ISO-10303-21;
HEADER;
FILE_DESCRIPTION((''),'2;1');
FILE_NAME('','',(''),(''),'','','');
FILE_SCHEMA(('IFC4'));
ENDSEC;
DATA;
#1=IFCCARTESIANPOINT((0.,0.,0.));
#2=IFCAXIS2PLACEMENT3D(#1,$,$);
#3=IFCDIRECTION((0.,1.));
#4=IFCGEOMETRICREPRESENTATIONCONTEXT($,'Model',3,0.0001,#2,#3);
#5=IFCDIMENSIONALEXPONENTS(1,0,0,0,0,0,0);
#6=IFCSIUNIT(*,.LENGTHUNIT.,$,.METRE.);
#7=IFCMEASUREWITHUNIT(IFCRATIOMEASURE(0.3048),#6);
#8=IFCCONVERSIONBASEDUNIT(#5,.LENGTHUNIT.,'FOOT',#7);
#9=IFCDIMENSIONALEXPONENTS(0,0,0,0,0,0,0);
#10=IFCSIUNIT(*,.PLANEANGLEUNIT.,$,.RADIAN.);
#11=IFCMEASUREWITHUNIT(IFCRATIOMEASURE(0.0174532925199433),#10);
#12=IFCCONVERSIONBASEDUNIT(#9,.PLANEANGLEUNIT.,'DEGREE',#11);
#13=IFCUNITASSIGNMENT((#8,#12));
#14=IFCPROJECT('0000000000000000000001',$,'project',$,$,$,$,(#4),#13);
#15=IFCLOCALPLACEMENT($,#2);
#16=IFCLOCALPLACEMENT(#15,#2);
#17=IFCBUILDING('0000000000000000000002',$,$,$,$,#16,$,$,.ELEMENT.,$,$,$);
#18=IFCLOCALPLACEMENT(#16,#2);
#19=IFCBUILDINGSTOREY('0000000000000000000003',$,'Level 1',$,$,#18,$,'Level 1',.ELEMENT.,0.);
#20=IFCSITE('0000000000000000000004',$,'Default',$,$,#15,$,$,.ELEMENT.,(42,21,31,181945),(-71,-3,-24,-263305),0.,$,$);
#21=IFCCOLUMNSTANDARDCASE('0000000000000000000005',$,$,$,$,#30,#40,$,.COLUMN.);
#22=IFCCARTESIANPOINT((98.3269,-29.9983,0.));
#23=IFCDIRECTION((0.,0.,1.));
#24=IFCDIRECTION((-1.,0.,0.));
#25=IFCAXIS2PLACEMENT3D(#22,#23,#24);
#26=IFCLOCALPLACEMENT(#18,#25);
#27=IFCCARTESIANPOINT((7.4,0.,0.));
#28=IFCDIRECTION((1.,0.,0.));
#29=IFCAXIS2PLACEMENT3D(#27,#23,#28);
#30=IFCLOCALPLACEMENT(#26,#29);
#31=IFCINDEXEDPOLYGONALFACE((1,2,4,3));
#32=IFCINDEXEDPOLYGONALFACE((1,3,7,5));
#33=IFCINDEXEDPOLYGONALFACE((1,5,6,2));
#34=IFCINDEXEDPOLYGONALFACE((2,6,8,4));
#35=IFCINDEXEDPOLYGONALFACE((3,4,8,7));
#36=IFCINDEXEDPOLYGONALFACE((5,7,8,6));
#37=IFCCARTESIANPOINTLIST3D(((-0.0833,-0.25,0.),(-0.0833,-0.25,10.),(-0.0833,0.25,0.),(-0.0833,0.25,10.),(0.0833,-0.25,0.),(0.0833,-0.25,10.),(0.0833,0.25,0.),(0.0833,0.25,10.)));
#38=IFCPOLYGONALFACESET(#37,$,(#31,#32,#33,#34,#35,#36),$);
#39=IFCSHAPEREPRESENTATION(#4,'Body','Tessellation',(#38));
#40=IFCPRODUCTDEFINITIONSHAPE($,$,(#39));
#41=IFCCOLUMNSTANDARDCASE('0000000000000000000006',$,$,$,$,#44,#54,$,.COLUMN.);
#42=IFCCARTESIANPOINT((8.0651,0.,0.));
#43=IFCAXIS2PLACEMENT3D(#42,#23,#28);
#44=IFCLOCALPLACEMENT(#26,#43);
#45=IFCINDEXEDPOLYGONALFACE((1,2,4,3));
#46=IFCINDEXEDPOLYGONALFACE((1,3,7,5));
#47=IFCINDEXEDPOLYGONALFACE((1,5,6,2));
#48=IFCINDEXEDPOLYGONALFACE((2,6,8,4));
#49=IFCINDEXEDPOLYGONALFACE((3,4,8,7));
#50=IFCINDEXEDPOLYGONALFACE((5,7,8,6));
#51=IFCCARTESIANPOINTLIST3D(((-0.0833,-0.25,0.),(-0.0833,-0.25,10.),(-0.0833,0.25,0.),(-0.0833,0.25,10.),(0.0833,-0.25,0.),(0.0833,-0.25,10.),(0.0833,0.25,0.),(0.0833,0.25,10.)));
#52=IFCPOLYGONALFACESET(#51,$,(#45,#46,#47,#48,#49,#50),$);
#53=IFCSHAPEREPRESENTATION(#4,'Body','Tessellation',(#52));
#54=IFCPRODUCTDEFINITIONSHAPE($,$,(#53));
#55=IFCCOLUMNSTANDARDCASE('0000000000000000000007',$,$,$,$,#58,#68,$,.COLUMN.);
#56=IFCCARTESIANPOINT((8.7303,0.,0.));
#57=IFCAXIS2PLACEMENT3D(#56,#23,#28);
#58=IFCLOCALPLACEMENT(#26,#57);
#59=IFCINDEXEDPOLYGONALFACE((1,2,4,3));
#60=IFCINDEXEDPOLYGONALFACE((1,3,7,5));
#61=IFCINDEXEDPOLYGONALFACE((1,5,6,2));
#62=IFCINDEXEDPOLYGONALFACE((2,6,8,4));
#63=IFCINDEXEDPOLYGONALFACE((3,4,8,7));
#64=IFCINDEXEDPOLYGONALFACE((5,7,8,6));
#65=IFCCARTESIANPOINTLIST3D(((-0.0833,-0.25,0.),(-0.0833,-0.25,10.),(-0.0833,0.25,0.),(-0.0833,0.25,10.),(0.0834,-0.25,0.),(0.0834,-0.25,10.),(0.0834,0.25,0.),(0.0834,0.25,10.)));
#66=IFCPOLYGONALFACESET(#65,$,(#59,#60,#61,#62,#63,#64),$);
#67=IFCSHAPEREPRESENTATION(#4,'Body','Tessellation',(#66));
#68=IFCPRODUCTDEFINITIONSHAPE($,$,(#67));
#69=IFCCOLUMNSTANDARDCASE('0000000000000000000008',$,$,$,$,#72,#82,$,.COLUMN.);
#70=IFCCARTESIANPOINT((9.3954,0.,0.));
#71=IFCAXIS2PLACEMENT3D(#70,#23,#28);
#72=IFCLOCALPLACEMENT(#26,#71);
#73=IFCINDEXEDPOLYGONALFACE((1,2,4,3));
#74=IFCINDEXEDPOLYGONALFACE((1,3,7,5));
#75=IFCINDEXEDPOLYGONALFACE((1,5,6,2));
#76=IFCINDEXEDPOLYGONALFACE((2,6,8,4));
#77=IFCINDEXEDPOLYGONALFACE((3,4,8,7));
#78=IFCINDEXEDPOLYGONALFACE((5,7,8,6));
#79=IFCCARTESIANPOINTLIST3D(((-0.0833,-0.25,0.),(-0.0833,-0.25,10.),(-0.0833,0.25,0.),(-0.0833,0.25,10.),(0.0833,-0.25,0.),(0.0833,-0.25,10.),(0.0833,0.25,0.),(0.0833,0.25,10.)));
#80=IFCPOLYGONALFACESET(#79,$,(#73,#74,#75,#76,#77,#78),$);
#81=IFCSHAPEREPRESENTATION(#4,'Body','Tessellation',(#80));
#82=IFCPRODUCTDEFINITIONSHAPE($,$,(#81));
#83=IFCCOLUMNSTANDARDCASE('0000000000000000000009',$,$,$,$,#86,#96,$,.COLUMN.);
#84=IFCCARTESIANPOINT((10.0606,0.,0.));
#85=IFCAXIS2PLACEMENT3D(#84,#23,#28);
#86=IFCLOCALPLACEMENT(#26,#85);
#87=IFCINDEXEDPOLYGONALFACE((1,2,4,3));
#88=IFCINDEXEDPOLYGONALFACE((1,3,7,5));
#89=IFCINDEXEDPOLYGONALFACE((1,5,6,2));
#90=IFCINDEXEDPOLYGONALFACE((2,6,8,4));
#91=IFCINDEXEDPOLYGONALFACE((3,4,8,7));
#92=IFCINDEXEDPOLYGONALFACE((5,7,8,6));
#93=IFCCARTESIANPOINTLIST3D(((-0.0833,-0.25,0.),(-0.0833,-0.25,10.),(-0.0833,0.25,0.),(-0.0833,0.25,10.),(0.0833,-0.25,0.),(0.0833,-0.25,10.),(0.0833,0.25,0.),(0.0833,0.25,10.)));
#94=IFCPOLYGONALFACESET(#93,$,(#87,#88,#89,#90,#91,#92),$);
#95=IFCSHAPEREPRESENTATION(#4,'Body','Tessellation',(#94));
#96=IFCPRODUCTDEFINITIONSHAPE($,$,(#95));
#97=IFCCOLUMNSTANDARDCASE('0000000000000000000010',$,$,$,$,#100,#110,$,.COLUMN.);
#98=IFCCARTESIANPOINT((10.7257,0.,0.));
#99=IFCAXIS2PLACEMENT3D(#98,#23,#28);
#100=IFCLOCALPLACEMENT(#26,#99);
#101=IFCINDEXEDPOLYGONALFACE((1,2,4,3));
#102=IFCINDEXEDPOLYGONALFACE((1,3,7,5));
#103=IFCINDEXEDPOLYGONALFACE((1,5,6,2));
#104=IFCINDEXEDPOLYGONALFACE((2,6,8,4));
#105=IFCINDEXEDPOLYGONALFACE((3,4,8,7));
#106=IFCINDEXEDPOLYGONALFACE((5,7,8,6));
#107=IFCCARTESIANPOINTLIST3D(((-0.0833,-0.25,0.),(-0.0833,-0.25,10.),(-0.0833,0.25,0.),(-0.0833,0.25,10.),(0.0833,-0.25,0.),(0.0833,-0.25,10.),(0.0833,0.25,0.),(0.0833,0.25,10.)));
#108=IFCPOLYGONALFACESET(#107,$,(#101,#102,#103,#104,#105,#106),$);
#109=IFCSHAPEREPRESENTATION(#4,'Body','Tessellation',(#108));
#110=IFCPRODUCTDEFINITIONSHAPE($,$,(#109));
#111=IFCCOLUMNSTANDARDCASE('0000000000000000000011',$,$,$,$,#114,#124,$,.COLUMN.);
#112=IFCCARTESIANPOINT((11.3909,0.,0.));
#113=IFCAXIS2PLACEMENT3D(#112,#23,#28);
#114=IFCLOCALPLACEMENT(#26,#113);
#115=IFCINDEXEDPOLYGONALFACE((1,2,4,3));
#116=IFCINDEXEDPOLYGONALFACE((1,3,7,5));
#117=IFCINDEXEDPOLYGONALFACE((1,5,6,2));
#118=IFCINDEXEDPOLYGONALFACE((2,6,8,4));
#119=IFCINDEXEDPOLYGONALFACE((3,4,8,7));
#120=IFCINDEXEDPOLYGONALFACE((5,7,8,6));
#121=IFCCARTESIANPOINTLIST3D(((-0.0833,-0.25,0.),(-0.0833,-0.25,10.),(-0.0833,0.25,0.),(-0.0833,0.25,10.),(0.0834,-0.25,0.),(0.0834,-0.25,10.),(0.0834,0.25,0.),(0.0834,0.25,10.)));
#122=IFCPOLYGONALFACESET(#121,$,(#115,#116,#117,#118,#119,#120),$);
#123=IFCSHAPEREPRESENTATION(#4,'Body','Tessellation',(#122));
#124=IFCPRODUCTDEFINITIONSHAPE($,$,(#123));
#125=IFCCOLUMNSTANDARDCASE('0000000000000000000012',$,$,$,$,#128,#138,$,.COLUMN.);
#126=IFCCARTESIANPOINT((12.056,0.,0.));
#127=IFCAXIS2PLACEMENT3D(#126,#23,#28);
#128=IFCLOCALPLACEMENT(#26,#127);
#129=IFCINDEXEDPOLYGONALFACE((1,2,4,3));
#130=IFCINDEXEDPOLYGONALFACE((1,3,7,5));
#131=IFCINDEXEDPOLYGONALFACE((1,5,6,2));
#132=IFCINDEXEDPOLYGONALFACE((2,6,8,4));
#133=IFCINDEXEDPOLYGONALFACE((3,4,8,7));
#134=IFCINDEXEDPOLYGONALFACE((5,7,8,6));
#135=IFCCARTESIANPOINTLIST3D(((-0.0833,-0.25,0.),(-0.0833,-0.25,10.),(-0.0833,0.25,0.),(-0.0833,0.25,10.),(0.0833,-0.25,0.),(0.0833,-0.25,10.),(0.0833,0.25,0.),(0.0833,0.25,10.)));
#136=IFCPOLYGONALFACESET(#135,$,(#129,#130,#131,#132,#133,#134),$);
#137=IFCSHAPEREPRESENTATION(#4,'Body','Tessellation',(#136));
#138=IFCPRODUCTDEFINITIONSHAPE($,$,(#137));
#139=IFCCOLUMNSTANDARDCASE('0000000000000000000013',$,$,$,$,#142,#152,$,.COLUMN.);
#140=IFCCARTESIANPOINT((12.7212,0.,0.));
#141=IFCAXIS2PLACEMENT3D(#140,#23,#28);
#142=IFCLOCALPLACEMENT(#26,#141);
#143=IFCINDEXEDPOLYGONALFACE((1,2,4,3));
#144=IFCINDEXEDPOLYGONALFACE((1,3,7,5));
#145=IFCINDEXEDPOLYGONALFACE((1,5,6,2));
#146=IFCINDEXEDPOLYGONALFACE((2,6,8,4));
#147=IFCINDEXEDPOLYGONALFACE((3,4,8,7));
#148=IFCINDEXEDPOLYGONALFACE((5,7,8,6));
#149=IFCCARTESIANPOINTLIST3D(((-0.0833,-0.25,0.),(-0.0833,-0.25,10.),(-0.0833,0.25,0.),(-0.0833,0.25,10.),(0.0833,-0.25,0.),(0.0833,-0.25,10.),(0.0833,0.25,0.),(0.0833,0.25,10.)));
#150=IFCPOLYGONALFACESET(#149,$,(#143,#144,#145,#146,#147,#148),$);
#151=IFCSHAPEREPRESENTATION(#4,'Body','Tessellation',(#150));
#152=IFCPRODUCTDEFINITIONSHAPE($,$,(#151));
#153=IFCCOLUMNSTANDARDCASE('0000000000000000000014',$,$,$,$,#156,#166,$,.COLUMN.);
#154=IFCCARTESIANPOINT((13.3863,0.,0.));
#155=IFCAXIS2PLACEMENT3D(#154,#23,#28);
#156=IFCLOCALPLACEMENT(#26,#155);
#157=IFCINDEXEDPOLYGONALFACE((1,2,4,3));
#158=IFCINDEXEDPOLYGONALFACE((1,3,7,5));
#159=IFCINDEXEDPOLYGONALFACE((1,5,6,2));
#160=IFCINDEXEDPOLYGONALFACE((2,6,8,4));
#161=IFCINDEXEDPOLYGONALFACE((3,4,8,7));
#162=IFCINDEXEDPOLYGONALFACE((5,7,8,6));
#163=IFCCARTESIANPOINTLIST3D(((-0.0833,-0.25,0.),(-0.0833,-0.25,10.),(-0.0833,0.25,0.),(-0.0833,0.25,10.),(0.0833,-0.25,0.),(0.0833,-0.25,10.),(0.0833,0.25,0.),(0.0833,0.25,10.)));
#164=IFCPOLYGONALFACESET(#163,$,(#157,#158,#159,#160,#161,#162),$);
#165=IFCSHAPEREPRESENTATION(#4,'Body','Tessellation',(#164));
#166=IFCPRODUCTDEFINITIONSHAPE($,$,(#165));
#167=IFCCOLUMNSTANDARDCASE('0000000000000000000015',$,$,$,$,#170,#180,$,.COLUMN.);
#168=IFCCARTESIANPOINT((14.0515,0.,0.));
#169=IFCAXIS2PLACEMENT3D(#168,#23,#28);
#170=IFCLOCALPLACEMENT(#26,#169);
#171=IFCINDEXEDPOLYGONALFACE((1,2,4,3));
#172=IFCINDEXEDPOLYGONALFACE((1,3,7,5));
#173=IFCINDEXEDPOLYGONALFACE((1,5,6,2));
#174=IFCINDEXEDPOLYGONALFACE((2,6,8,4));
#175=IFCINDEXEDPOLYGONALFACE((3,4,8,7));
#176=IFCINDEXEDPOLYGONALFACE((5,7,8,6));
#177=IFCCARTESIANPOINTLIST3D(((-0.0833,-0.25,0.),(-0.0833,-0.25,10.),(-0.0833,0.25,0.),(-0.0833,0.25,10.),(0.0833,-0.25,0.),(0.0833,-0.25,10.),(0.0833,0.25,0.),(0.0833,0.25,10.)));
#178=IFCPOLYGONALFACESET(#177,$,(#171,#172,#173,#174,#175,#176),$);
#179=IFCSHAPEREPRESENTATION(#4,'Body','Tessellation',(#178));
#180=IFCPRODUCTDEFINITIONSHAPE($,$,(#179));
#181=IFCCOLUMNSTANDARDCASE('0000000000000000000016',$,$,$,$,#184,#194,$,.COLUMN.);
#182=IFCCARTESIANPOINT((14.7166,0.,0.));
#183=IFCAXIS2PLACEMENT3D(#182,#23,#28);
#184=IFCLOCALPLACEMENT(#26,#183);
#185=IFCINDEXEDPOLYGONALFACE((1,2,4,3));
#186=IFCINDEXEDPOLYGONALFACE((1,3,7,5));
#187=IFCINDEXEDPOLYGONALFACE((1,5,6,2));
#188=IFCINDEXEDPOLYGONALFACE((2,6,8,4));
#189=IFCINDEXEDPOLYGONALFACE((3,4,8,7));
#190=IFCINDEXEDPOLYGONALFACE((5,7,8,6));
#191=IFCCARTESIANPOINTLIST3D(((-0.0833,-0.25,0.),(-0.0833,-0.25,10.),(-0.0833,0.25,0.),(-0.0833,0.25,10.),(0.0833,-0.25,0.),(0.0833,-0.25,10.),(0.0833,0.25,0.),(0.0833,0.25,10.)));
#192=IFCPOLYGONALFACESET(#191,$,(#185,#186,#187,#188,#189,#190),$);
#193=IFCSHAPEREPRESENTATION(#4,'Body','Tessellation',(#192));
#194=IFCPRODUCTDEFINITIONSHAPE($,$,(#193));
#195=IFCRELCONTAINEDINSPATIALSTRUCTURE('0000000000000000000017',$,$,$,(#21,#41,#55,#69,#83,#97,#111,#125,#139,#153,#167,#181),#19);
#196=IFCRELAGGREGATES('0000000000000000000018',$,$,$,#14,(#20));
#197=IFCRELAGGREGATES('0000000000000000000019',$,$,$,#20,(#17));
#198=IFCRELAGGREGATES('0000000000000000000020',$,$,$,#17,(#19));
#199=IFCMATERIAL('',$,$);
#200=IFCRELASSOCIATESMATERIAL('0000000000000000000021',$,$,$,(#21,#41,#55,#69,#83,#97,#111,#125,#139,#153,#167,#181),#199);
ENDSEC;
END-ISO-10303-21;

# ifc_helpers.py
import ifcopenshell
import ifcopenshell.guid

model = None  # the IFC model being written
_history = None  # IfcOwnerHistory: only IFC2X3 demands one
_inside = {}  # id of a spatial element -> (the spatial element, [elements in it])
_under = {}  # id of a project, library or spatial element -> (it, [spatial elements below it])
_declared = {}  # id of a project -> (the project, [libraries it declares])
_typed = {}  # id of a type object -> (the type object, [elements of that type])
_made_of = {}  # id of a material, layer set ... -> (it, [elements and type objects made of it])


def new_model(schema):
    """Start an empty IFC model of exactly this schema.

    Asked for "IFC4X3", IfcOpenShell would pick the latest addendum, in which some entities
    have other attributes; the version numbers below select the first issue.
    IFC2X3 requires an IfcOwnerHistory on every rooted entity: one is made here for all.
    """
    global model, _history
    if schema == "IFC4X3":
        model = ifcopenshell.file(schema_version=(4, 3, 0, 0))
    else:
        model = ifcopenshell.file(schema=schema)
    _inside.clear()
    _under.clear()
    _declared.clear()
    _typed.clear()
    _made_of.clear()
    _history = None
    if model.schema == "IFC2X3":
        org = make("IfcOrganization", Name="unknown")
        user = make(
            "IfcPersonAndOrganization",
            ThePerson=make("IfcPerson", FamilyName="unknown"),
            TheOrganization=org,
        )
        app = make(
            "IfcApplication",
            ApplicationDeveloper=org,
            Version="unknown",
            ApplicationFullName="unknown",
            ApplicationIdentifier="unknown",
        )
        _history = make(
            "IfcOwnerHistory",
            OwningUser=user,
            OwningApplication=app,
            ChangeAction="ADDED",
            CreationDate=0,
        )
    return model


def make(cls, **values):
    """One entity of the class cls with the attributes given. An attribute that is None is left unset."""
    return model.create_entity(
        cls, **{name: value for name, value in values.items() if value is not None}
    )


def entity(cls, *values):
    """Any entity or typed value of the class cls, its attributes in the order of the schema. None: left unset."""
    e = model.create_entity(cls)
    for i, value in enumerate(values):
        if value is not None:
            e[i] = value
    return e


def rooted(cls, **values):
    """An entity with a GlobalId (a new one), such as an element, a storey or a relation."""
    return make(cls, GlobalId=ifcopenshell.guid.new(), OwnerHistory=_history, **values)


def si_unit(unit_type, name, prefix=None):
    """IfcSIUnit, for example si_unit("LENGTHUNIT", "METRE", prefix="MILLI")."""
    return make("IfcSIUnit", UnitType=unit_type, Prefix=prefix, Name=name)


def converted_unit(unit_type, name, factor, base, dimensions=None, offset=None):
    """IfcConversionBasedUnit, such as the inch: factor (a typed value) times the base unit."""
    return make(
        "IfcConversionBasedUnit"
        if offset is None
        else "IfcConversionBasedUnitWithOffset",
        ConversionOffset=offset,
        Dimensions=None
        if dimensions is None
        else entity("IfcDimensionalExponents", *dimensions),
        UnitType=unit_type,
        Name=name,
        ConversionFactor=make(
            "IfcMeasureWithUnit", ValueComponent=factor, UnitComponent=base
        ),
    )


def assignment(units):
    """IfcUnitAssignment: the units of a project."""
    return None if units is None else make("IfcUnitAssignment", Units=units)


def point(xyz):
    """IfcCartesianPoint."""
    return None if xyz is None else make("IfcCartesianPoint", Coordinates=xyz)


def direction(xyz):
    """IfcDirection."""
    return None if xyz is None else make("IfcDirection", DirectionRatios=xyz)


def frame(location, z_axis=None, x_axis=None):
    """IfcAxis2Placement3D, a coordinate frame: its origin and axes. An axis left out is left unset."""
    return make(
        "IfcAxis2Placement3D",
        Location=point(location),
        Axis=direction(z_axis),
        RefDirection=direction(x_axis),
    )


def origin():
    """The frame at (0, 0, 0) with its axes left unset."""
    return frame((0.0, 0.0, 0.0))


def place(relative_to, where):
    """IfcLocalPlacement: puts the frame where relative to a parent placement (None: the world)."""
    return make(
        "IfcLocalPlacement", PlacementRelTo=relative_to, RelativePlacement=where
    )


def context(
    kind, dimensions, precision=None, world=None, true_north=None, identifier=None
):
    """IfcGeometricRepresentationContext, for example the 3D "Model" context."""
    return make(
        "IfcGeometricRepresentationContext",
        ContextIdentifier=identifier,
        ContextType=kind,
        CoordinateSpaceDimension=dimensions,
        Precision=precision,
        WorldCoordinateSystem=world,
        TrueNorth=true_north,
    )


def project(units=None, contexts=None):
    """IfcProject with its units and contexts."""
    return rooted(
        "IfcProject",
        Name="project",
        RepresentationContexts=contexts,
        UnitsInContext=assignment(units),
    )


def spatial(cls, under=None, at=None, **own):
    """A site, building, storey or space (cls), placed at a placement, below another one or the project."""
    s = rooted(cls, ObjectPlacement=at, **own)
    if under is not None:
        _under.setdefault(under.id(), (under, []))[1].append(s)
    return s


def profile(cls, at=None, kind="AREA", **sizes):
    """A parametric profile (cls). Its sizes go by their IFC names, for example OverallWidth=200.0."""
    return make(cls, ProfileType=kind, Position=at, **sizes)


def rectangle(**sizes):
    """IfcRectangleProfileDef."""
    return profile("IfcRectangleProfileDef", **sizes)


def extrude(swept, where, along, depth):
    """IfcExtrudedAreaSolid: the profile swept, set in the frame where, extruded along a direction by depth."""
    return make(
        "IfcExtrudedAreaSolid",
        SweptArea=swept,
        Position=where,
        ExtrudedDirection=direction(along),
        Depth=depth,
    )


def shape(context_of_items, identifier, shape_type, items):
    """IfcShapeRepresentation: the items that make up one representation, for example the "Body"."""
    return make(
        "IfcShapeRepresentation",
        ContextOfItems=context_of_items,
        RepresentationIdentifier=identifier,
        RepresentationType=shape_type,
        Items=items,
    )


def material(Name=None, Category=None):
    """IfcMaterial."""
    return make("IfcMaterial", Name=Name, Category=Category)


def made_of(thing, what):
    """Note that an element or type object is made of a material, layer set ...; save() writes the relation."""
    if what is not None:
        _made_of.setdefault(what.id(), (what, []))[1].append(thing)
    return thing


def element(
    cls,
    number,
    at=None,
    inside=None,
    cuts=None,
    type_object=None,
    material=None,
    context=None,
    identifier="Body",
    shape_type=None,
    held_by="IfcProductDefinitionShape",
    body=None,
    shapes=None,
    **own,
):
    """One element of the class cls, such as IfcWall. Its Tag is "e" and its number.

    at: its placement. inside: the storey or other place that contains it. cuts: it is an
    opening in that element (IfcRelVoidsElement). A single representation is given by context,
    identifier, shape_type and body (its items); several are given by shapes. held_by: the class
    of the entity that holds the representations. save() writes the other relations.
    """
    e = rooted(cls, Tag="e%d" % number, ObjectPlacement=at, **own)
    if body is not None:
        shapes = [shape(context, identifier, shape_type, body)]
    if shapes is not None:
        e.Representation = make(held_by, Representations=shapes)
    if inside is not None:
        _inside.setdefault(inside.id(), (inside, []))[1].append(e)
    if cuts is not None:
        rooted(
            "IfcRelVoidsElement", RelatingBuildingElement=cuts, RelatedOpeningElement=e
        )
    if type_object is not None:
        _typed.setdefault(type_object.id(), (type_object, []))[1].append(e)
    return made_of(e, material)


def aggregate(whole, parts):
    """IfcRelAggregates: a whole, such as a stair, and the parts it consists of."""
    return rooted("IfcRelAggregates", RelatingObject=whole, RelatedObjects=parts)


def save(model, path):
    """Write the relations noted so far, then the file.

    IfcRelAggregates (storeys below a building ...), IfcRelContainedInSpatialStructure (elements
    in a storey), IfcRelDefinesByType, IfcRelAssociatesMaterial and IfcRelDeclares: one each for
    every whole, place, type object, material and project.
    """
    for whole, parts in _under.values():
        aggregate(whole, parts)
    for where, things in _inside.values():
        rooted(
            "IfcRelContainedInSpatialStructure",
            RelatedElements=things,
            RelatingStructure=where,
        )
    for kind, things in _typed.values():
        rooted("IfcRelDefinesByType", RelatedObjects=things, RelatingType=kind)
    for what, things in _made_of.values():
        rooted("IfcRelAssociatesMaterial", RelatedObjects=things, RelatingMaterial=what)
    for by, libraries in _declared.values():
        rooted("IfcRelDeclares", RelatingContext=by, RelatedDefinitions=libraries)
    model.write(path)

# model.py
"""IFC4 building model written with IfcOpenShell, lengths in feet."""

from ifc_helpers import new_model, entity, si_unit, converted_unit, direction, frame, origin, place, context, project, spatial, rectangle, extrude, material, element, save


model = new_model("IFC4")

# Units and contexts
model_context = context("Model", 3, precision=0.0001, world=origin(), true_north=direction((0.0, 1.0)))
ifc_project = project(units=[converted_unit("LENGTHUNIT", "FOOT", entity("IfcRatioMeasure", 0.3048), si_unit("LENGTHUNIT", "METRE"), dimensions=[1, 0, 0, 0, 0, 0, 0]), converted_unit("PLANEANGLEUNIT", "DEGREE", entity("IfcRatioMeasure", 0.0174532925199433), si_unit("PLANEANGLEUNIT", "RADIAN"), dimensions=[0, 0, 0, 0, 0, 0, 0])], contexts=[model_context])

# Site, building, storey
site_placement = place(None, origin())
site = spatial("IfcSite", under=ifc_project, at=site_placement, Name="Default", CompositionType="ELEMENT", RefLatitude=(42, 21, 31, 181945), RefLongitude=(-71, -3, -24, -263305), RefElevation=0.0)
building_placement = place(site_placement, origin())
building = spatial("IfcBuilding", under=site, at=building_placement, CompositionType="ELEMENT")
storey_placement = place(building_placement, origin())
storey = spatial("IfcBuildingStorey", under=building, at=storey_placement, Name="Level 1", LongName="Level 1", CompositionType="ELEMENT", Elevation=0.0)

# Columns
ifc_material = material(Name="")
placement = place(storey_placement, frame((98.3269, -29.9983, 0.0), z_axis=(0.0, 0.0, 1.0), x_axis=(-1.0, 0.0, 0.0)))
for number, where, z_axis, x_axis in (
    (1, (7.4, 0.0, 0.0), (0.0, 0.0, 1.0), (1.0, 0.0, 0.0)),
    (2, (8.0651, 0.0, 0.0), (0.0, 0.0, 1.0), (1.0, 0.0, 0.0)),
    (3, (8.7303, 0.0, 0.0), (0.0, 0.0, 1.0), (1.0, 0.0, 0.0)),
    (4, (9.3954, 0.0, 0.0), (0.0, 0.0, 1.0), (1.0, 0.0, 0.0)),
    (5, (10.0606, 0.0, 0.0), (0.0, 0.0, 1.0), (1.0, 0.0, 0.0)),
    (6, (10.7257, 0.0, 0.0), (0.0, 0.0, 1.0), (1.0, 0.0, 0.0)),
    (7, (11.3909, 0.0, 0.0), (0.0, 0.0, 1.0), (1.0, 0.0, 0.0)),
    (8, (12.056, 0.0, 0.0), (0.0, 0.0, 1.0), (1.0, 0.0, 0.0)),
    (9, (12.7212, 0.0, 0.0), (0.0, 0.0, 1.0), (1.0, 0.0, 0.0)),
    (10, (13.3863, 0.0, 0.0), (0.0, 0.0, 1.0), (1.0, 0.0, 0.0)),
    (11, (14.0515, 0.0, 0.0), (0.0, 0.0, 1.0), (1.0, 0.0, 0.0)),
    (12, (14.7166, 0.0, 0.0), (0.0, 0.0, 1.0), (1.0, 0.0, 0.0)),
):
    element("IfcColumnStandardCase", number, at=place(placement, frame(where, z_axis=z_axis, x_axis=x_axis)), inside=storey, material=ifc_material, PredefinedType="COLUMN", context=model_context, shape_type="SweptSolid", body=[
        extrude(rectangle(XDim=0.1667, YDim=0.5), origin(), (0.0, 0.0, 1.0), 10.0),
    ])

save(model, "model.ifc")
